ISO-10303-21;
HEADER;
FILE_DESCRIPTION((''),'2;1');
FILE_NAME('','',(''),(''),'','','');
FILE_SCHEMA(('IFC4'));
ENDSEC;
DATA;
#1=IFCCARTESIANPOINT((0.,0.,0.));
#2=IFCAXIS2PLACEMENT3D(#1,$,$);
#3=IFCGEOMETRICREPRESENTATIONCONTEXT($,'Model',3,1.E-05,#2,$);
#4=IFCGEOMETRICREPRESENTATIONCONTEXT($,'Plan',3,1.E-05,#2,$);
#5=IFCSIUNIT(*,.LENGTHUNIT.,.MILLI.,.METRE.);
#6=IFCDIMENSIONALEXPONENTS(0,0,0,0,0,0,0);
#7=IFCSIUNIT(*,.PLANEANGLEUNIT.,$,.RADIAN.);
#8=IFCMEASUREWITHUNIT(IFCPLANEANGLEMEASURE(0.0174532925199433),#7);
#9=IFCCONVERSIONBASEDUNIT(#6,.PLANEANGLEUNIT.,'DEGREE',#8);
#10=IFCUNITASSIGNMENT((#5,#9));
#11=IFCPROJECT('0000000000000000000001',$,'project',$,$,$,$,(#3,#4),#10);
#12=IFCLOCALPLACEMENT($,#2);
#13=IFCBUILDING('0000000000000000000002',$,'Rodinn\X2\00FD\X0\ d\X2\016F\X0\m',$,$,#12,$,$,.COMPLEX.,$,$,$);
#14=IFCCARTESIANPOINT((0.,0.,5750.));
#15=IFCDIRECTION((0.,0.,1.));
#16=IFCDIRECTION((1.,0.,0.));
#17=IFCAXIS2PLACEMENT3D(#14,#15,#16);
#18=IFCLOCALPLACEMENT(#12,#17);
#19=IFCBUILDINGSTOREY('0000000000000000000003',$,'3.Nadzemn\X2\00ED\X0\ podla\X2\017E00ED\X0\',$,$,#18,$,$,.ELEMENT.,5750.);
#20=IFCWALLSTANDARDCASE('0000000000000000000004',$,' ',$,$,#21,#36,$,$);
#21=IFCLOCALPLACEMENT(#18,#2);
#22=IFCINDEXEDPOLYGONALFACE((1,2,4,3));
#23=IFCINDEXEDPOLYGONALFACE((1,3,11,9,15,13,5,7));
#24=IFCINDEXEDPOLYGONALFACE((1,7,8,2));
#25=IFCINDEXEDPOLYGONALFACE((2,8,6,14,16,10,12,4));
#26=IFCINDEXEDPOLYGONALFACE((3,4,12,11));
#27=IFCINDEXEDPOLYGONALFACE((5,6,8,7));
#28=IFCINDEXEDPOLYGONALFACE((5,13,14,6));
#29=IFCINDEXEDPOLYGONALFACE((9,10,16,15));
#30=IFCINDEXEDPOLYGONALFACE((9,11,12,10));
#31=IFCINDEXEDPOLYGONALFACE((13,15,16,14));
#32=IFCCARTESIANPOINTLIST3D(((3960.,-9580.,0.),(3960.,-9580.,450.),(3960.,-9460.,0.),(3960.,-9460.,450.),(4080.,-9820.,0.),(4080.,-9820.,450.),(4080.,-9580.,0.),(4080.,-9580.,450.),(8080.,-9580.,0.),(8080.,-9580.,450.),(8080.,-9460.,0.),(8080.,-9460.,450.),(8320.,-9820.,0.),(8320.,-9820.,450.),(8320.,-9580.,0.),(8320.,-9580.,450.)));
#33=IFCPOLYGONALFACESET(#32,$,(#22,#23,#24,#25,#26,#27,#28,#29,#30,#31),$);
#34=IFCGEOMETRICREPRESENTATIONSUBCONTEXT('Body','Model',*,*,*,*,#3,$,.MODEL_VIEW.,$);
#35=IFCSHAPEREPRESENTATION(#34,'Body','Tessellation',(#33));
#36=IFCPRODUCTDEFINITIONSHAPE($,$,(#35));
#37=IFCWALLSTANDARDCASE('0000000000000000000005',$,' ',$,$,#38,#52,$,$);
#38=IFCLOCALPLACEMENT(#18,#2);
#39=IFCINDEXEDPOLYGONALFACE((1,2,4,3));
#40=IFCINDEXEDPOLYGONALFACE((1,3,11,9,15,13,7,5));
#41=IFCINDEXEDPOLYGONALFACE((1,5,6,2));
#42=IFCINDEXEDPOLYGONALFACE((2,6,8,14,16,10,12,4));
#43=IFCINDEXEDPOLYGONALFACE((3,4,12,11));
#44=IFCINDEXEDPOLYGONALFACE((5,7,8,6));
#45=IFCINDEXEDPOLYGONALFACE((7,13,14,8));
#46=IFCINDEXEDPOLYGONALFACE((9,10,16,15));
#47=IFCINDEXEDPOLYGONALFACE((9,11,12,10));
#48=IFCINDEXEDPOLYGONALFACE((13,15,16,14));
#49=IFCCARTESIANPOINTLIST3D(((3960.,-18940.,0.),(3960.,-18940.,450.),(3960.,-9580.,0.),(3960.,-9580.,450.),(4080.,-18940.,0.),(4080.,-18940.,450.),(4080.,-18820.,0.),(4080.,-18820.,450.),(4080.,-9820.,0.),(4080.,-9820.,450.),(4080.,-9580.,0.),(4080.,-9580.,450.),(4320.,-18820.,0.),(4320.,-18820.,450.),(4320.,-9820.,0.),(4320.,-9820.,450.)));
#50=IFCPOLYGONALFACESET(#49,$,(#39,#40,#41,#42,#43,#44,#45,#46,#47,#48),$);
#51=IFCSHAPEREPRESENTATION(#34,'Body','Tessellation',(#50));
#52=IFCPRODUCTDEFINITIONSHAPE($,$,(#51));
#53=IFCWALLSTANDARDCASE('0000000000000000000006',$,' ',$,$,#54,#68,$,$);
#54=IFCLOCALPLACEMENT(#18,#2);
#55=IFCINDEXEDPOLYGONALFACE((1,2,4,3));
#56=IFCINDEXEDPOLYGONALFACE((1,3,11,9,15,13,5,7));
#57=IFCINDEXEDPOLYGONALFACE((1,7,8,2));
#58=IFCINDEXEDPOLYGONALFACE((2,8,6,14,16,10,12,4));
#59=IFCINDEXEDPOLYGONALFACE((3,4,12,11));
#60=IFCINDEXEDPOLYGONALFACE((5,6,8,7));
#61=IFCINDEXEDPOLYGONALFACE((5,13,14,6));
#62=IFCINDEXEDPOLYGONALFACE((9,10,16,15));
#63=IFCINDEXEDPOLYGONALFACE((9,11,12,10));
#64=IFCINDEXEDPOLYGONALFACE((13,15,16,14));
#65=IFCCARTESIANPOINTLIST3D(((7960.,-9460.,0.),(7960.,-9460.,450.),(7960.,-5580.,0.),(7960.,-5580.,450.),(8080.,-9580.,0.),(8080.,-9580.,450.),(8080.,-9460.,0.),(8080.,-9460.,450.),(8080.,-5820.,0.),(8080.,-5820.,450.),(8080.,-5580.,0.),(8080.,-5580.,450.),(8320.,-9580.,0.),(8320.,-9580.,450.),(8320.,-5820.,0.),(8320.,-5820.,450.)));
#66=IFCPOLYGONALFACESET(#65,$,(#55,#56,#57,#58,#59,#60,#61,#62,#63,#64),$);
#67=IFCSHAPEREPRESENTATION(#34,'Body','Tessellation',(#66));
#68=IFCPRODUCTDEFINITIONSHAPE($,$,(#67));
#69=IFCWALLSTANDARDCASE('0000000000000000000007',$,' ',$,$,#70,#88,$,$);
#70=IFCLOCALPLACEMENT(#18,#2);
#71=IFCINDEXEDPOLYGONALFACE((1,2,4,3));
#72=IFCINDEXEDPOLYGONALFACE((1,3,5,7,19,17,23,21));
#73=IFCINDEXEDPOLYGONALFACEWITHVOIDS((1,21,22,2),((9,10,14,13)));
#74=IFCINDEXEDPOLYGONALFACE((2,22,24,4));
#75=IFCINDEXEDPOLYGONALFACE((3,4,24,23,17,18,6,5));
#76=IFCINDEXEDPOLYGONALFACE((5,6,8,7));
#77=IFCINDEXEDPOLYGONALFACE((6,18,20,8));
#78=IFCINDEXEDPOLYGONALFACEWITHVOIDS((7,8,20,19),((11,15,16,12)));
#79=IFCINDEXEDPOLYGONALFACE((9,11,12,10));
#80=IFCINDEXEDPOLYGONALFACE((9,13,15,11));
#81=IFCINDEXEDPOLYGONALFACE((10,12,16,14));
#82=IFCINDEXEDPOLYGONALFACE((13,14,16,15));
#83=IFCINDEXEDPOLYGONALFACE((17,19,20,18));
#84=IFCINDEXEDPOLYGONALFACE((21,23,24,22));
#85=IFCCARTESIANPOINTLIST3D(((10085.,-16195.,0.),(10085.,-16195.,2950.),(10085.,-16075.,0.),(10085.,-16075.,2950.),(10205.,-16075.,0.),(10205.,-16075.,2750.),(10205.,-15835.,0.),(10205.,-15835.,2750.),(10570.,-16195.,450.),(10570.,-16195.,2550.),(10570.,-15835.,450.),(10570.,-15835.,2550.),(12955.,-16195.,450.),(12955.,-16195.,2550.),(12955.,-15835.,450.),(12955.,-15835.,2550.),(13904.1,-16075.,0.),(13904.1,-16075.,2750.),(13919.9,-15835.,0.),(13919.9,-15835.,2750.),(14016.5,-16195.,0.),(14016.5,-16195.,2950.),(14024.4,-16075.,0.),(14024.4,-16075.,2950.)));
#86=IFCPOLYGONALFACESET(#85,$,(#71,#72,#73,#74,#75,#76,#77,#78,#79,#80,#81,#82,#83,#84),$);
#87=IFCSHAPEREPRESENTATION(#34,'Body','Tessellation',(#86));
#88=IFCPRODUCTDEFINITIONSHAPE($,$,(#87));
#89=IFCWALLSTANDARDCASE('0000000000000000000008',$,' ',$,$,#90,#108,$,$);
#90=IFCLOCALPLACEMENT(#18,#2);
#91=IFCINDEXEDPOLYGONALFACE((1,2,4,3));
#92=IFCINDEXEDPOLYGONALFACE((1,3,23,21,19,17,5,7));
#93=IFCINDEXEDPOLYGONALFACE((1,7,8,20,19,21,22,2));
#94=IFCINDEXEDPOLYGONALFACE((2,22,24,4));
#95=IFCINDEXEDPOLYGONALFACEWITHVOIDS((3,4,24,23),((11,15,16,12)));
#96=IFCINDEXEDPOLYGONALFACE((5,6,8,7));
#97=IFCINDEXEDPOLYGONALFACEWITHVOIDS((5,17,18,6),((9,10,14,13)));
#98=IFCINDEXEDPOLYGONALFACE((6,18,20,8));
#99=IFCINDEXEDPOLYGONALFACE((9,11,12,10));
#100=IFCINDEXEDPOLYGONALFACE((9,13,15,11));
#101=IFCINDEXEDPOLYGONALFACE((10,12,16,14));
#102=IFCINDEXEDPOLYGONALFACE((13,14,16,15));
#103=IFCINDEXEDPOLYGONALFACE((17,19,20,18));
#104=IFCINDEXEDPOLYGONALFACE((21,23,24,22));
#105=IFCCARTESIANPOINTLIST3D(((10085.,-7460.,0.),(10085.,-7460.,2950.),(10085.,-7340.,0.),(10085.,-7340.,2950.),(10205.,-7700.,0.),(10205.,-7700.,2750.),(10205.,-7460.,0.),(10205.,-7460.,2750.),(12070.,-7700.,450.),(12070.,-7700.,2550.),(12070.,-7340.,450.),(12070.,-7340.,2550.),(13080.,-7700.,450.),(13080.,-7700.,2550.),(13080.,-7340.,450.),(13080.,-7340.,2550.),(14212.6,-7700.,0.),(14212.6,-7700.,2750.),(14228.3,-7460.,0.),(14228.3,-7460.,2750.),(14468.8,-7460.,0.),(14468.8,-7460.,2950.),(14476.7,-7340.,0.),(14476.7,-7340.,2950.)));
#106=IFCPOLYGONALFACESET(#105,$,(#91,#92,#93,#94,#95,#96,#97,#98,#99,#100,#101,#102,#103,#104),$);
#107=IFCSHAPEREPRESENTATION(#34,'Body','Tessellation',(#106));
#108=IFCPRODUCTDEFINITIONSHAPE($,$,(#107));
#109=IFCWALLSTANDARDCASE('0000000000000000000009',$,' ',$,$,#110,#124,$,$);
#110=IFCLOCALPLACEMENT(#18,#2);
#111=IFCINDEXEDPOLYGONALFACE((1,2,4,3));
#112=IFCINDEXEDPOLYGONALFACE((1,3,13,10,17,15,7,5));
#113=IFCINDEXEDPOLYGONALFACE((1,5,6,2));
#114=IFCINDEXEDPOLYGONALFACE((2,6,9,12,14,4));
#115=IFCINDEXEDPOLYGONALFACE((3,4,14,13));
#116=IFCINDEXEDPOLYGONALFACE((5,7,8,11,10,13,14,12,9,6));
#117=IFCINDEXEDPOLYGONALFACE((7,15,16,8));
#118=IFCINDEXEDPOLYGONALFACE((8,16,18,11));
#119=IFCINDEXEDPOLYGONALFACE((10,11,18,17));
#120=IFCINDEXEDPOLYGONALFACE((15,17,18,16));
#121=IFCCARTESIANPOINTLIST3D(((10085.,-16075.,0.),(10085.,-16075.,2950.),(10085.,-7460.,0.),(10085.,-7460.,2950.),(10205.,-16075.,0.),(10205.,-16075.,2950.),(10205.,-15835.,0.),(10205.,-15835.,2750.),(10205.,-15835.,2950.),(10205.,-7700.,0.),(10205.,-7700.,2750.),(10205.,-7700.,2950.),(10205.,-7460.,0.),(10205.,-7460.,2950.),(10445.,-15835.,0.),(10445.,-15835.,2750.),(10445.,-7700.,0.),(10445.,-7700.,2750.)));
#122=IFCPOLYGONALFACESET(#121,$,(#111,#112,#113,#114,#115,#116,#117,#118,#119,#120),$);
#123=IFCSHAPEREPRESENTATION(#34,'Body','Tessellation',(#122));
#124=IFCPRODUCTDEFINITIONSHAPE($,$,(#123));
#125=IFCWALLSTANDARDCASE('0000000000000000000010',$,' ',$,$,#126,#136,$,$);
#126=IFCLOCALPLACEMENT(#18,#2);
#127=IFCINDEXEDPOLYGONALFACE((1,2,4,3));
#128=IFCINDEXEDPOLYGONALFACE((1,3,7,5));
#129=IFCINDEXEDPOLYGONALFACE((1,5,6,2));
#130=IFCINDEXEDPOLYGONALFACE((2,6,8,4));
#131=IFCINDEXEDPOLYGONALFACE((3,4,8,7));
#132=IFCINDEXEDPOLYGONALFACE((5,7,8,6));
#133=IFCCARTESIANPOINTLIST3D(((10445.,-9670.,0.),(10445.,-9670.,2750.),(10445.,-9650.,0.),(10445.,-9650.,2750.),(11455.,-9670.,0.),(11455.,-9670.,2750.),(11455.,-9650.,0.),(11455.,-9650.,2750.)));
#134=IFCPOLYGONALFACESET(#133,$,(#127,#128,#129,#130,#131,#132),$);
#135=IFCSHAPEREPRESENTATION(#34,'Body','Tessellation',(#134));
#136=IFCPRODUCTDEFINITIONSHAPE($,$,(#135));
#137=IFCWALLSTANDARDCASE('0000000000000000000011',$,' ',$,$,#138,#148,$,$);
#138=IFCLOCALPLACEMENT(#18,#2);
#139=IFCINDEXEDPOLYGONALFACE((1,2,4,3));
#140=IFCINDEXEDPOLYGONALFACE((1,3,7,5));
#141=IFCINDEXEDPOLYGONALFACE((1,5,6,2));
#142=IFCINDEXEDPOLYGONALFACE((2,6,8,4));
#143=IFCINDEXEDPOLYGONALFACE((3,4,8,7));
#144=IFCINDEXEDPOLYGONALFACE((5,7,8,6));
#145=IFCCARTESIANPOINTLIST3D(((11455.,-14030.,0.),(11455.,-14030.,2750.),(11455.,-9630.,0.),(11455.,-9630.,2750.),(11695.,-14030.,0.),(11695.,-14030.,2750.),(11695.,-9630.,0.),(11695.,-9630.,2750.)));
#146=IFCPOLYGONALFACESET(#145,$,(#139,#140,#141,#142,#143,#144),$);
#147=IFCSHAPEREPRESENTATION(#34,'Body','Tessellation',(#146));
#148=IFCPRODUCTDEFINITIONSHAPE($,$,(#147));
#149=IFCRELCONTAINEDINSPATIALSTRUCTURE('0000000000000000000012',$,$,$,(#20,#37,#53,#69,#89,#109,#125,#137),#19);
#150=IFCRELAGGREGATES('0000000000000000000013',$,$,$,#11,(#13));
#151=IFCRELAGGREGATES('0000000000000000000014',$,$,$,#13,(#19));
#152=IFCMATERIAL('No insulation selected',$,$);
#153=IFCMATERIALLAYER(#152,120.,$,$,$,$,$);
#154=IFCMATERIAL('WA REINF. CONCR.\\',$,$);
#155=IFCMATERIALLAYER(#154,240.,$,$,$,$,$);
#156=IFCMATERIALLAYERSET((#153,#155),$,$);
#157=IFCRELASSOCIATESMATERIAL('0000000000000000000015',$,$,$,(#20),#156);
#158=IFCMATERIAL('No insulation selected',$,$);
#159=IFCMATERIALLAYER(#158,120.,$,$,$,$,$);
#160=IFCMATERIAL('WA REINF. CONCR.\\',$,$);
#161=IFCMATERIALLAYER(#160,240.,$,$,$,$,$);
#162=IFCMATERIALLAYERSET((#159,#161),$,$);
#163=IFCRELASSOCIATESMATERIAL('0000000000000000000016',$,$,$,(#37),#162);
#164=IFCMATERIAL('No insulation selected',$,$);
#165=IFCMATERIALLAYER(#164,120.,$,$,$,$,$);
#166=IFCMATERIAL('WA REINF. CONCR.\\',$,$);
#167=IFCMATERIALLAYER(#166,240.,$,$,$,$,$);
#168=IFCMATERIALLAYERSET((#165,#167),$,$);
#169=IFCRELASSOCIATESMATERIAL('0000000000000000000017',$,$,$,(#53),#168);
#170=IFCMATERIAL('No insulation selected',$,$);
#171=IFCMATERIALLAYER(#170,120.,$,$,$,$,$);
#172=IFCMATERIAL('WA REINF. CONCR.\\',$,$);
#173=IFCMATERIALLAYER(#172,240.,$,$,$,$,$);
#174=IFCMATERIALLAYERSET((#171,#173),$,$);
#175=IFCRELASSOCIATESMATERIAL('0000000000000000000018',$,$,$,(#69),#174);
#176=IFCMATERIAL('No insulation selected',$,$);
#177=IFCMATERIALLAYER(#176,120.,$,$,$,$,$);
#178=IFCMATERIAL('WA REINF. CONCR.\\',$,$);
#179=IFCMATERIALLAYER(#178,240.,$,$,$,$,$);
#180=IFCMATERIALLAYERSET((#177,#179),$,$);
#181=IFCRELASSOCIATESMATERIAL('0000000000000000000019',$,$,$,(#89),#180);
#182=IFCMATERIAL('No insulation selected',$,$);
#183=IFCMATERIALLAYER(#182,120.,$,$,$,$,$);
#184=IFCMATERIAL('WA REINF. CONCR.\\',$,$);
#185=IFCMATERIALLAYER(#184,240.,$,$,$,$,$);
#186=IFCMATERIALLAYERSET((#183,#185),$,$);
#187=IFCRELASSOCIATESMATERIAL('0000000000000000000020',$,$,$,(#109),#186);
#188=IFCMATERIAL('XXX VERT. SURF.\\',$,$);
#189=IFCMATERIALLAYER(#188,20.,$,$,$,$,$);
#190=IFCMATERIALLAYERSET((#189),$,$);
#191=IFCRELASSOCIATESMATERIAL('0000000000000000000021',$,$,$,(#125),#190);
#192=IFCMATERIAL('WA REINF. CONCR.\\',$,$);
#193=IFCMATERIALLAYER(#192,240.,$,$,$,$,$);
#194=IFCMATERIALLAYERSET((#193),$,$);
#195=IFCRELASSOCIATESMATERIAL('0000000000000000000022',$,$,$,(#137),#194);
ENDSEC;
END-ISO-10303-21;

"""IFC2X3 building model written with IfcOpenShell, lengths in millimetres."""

from ifc_helpers import new_model, entity, si_unit, converted_unit, frame, frame_2d, origin, origin_with_axes, place, context, subcontext, project, spatial, polyline, rectangle, outline, extrude, clip, bounded_halfspace, material, layer, layer_set, layer_usage, element, save


model = new_model("IFC2X3")

# Units and contexts
model_context = context("Model", 3, precision=1e-05, world=origin())
plan_context = context("Plan", 3, precision=1e-05, world=origin())
body_context = subcontext(model_context, "Body", "Model", "MODEL_VIEW")
ifc_project = project(units=[si_unit("LENGTHUNIT", "METRE", prefix="MILLI"), converted_unit("PLANEANGLEUNIT", "DEGREE", entity("IfcPlaneAngleMeasure", 0.0174532925199433), si_unit("PLANEANGLEUNIT", "RADIAN"), dimensions=[0, 0, 0, 0, 0, 0, 0])], contexts=[model_context, plan_context])

# Building, storey
building_placement = place(None, origin())
building = spatial("IfcBuilding", under=ifc_project, at=building_placement, Name="Rodinný dům", CompositionType="COMPLEX")
storey_placement = place(building_placement, frame((0.0, 0.0, 5750.0), z_axis=(0.0, 0.0, 1.0), x_axis=(1.0, 0.0, 0.0)))
storey = spatial("IfcBuildingStorey", under=building, at=storey_placement, Name="3.Nadzemní podlaží", CompositionType="ELEMENT", Elevation=5750.0)

# Walls
ifc_material_1 = material(Name="No insulation selected")
ifc_layer_1 = layer(ifc_material_1, 120.0)
ifc_material_2 = material(Name="WA REINF. CONCR.\\")
ifc_layer_2 = layer(ifc_material_2, 240.0)
ifc_layer_set_1 = layer_set([ifc_layer_1, ifc_layer_2])
ifc_layer_usage_1 = layer_usage(ifc_layer_set_1, "AXIS2", "POSITIVE", -120.0)
wall_1_placement = place(storey_placement, frame((8080.0, -9460.0, 0.0), z_axis=(0.0, 0.0, 1.0), x_axis=(-1.0, 0.0, 0.0)))
element("IfcWallStandardCase", 1, at=wall_1_placement, inside=storey, material=ifc_layer_usage_1, Name=" ", context=body_context, shape_type="SweptSolid", body=[
    extrude(outline(polyline([(0.0, 0.0), (4120.0, 0.0), (4120.0, 120.0), (4000.0, 120.0), (4000.0, 360.0), (-240.0, 360.0), (-240.0, 120.0), (0.0, 120.0), (0.0, 0.0)])), origin_with_axes(), (0.0, 0.0, 1.0), 450.0),
])
ifc_material_3 = material(Name="No insulation selected")
ifc_layer_3 = layer(ifc_material_3, 120.0)
ifc_material_4 = material(Name="WA REINF. CONCR.\\")
ifc_layer_4 = layer(ifc_material_4, 240.0)
ifc_layer_set_2 = layer_set([ifc_layer_3, ifc_layer_4])
ifc_layer_usage_2 = layer_usage(ifc_layer_set_2, "AXIS2", "POSITIVE", -120.0)
wall_2_placement = place(storey_placement, frame((3960.0, -9580.0, 0.0), z_axis=(0.0, 0.0, 1.0), x_axis=(0.0, -1.0, 0.0)))
element("IfcWallStandardCase", 2, at=wall_2_placement, inside=storey, material=ifc_layer_usage_2, Name=" ", context=body_context, shape_type="SweptSolid", body=[
    extrude(outline(polyline([(0.0, 0.0), (9360.0, 0.0), (9360.0, 120.0), (9240.0, 120.0), (9240.0, 360.0), (240.0, 360.0), (240.0, 120.0), (0.0, 120.0), (0.0, 0.0)])), origin_with_axes(), (0.0, 0.0, 1.0), 450.0),
])
ifc_material_5 = material(Name="No insulation selected")
ifc_layer_5 = layer(ifc_material_5, 120.0)
ifc_material_6 = material(Name="WA REINF. CONCR.\\")
ifc_layer_6 = layer(ifc_material_6, 240.0)
ifc_layer_set_3 = layer_set([ifc_layer_5, ifc_layer_6])
ifc_layer_usage_3 = layer_usage(ifc_layer_set_3, "AXIS2", "POSITIVE", -120.0)
wall_3_placement = place(storey_placement, frame((7960.0, -5580.0, 0.0), z_axis=(0.0, 0.0, 1.0), x_axis=(0.0, -1.0, 0.0)))
element("IfcWallStandardCase", 3, at=wall_3_placement, inside=storey, material=ifc_layer_usage_3, Name=" ", context=body_context, shape_type="SweptSolid", body=[
    extrude(outline(polyline([(0.0, 0.0), (3880.0, 0.0), (3880.0, 120.0), (4000.0, 120.0), (4000.0, 360.0), (240.0, 360.0), (240.0, 120.0), (0.0, 120.0), (0.0, 0.0)])), origin_with_axes(), (0.0, 0.0, 1.0), 450.0),
])

# Walls, openings
ifc_material_7 = material(Name="No insulation selected")
ifc_layer_7 = layer(ifc_material_7, 120.0)
ifc_material_8 = material(Name="WA REINF. CONCR.\\")
ifc_layer_8 = layer(ifc_material_8, 240.0)
ifc_layer_set_4 = layer_set([ifc_layer_7, ifc_layer_8])
ifc_layer_usage_4 = layer_usage(ifc_layer_set_4, "AXIS2", "POSITIVE", -120.0)
wall_4_placement = place(storey_placement, frame((10085.0, -16195.0, 0.0), z_axis=(0.0, 0.0, 1.0), x_axis=(1.0, 0.0, 0.0)))
wall_4 = element("IfcWallStandardCase", 4, at=wall_4_placement, inside=storey, material=ifc_layer_usage_4, Name=" ", context=body_context, shape_type="Clipping", body=[
    clip(clip(extrude(outline(polyline([(0.0, 0.0), (3931.5, 0.0), (3939.4, 120.0), (3819.1, 120.0), (3834.9, 360.0), (120.0, 360.0), (120.0, 120.0), (0.0, 120.0), (0.0, 0.0)])), origin_with_axes(), (0.0, 0.0, 1.0), 2950.0), bounded_halfspace(frame((0.0, 0.0, 2950.0), z_axis=(0.0, 0.0, -1.0), x_axis=(1.0, 0.0, 0.0)), True, origin(), polyline([(0.0, 0.0), (3931.5, 0.0), (3939.4, 120.0), (0.0, 120.0), (0.0, 0.0)]))), bounded_halfspace(frame((120.0, 120.0, 2750.0), z_axis=(0.0, 0.0, -1.0), x_axis=(1.0, 0.0, 0.0)), True, origin(), polyline([(120.0, 120.0), (3819.1, 120.0), (3834.9, 360.0), (120.0, 360.0), (120.0, 120.0)]))),
])
opening_1_placement = place(wall_4_placement, frame((485.0, 0.0, 450.0), z_axis=(0.0, 1.0, 0.0), x_axis=(0.0, 0.0, 1.0)))
element("IfcOpeningElement", 5, at=opening_1_placement, cuts=wall_4, ObjectType="Opening", context=body_context, shape_type="SweptSolid", body=[
    extrude(rectangle(XDim=2100.0, YDim=2385.0, at=frame_2d((1050.0, 1192.5), x_axis=(1.0, 0.0))), origin_with_axes(), (0.0, 0.0, 1.0), 360.0),
])
ifc_material_9 = material(Name="No insulation selected")
ifc_layer_9 = layer(ifc_material_9, 120.0)
ifc_material_10 = material(Name="WA REINF. CONCR.\\")
ifc_layer_10 = layer(ifc_material_10, 240.0)
ifc_layer_set_5 = layer_set([ifc_layer_9, ifc_layer_10])
ifc_layer_usage_5 = layer_usage(ifc_layer_set_5, "AXIS2", "POSITIVE", -120.0)
wall_5_placement = place(storey_placement, frame((14476.7, -7340.0, 0.0), z_axis=(0.0, 0.0, 1.0), x_axis=(-1.0, 0.0, 0.0)))
wall_5 = element("IfcWallStandardCase", 6, at=wall_5_placement, inside=storey, material=ifc_layer_usage_5, Name=" ", context=body_context, shape_type="Clipping", body=[
    clip(clip(extrude(outline(polyline([(0.0, 0.0), (4391.7, 0.0), (4391.7, 120.0), (4271.7, 120.0), (4271.7, 360.0), (264.1, 360.0), (248.4, 120.0), (7.9, 120.0), (0.0, 0.0)])), origin_with_axes(), (0.0, 0.0, 1.0), 2950.0), bounded_halfspace(frame((0.0, 0.0, 2950.0), z_axis=(0.0, 0.0, -1.0), x_axis=(1.0, 0.0, 0.0)), True, origin(), polyline([(0.0, 0.0), (4391.7, 0.0), (4391.7, 120.0), (7.9, 120.0), (0.0, 0.0)]))), bounded_halfspace(frame((248.4, 120.0, 2750.0), z_axis=(0.0, 0.0, -1.0), x_axis=(1.0, 0.0, 0.0)), True, origin(), polyline([(248.4, 120.0), (4271.7, 120.0), (4271.7, 360.0), (264.1, 360.0), (248.4, 120.0)]))),
])
opening_2_placement = place(wall_5_placement, frame((1396.7, 0.0, 450.0), z_axis=(0.0, 1.0, 0.0), x_axis=(0.0, 0.0, 1.0)))
element("IfcOpeningElement", 7, at=opening_2_placement, cuts=wall_5, ObjectType="Opening", context=body_context, shape_type="SweptSolid", body=[
    extrude(rectangle(XDim=2100.0, YDim=1010.0, at=frame_2d((1050.0, 505.0), x_axis=(1.0, 0.0))), origin_with_axes(), (0.0, 0.0, 1.0), 360.0),
])

# Walls
ifc_material_11 = material(Name="No insulation selected")
ifc_layer_11 = layer(ifc_material_11, 120.0)
ifc_material_12 = material(Name="WA REINF. CONCR.\\")
ifc_layer_12 = layer(ifc_material_12, 240.0)
ifc_layer_set_6 = layer_set([ifc_layer_11, ifc_layer_12])
ifc_layer_usage_6 = layer_usage(ifc_layer_set_6, "AXIS2", "POSITIVE", -120.0)
wall_6_placement = place(storey_placement, frame((10085.0, -7460.0, 0.0), z_axis=(0.0, 0.0, 1.0), x_axis=(0.0, -1.0, 0.0)))
element("IfcWallStandardCase", 8, at=wall_6_placement, inside=storey, material=ifc_layer_usage_6, Name=" ", context=body_context, shape_type="Clipping", body=[
    clip(clip(extrude(outline(polyline([(0.0, 0.0), (8615.0, 0.0), (8615.0, 120.0), (8375.0, 120.0), (8375.0, 360.0), (240.0, 360.0), (240.0, 120.0), (0.0, 120.0), (0.0, 0.0)])), origin_with_axes(), (0.0, 0.0, 1.0), 2950.0), bounded_halfspace(frame((0.0, 0.0, 2950.0), z_axis=(0.0, 0.0, -1.0), x_axis=(1.0, 0.0, 0.0)), True, origin(), polyline([(0.0, 0.0), (8615.0, 0.0), (8615.0, 120.0), (0.0, 120.0), (0.0, 0.0)]))), bounded_halfspace(frame((240.0, 120.0, 2750.0), z_axis=(0.0, 0.0, -1.0), x_axis=(1.0, 0.0, 0.0)), True, origin(), polyline([(240.0, 120.0), (8375.0, 120.0), (8375.0, 360.0), (240.0, 360.0), (240.0, 120.0)]))),
])
ifc_material_13 = material(Name="XXX VERT. SURF.\\")
ifc_layer_13 = layer(ifc_material_13, 20.0)
ifc_layer_set_7 = layer_set([ifc_layer_13])
ifc_layer_usage_7 = layer_usage(ifc_layer_set_7, "AXIS2", "POSITIVE", 0.0)
wall_7_placement = place(storey_placement, frame((10445.0, -9670.0, 0.0), z_axis=(0.0, 0.0, 1.0), x_axis=(1.0, 0.0, 0.0)))
element("IfcWallStandardCase", 9, at=wall_7_placement, inside=storey, material=ifc_layer_usage_7, Name=" ", context=body_context, shape_type="SweptSolid", body=[
    extrude(rectangle(XDim=1010.0, YDim=20.0, at=frame_2d((505.0, 10.0), x_axis=(1.0, 0.0))), origin_with_axes(), (0.0, 0.0, 1.0), 2750.0),
])
ifc_material_14 = material(Name="WA REINF. CONCR.\\")
ifc_layer_14 = layer(ifc_material_14, 240.0)
ifc_layer_set_8 = layer_set([ifc_layer_14])
ifc_layer_usage_8 = layer_usage(ifc_layer_set_8, "AXIS2", "POSITIVE", 0.0)
wall_8_placement = place(storey_placement, frame((11455.0, -9630.0, 0.0), z_axis=(0.0, 0.0, 1.0), x_axis=(0.0, -1.0, 0.0)))
element("IfcWallStandardCase", 10, at=wall_8_placement, inside=storey, material=ifc_layer_usage_8, Name=" ", context=body_context, shape_type="SweptSolid", body=[
    extrude(rectangle(XDim=4400.0, YDim=240.0, at=frame_2d((2200.0, 120.0), x_axis=(1.0, 0.0))), origin_with_axes(), (0.0, 0.0, 1.0), 2750.0),
])

save(model, "model.ifc")
